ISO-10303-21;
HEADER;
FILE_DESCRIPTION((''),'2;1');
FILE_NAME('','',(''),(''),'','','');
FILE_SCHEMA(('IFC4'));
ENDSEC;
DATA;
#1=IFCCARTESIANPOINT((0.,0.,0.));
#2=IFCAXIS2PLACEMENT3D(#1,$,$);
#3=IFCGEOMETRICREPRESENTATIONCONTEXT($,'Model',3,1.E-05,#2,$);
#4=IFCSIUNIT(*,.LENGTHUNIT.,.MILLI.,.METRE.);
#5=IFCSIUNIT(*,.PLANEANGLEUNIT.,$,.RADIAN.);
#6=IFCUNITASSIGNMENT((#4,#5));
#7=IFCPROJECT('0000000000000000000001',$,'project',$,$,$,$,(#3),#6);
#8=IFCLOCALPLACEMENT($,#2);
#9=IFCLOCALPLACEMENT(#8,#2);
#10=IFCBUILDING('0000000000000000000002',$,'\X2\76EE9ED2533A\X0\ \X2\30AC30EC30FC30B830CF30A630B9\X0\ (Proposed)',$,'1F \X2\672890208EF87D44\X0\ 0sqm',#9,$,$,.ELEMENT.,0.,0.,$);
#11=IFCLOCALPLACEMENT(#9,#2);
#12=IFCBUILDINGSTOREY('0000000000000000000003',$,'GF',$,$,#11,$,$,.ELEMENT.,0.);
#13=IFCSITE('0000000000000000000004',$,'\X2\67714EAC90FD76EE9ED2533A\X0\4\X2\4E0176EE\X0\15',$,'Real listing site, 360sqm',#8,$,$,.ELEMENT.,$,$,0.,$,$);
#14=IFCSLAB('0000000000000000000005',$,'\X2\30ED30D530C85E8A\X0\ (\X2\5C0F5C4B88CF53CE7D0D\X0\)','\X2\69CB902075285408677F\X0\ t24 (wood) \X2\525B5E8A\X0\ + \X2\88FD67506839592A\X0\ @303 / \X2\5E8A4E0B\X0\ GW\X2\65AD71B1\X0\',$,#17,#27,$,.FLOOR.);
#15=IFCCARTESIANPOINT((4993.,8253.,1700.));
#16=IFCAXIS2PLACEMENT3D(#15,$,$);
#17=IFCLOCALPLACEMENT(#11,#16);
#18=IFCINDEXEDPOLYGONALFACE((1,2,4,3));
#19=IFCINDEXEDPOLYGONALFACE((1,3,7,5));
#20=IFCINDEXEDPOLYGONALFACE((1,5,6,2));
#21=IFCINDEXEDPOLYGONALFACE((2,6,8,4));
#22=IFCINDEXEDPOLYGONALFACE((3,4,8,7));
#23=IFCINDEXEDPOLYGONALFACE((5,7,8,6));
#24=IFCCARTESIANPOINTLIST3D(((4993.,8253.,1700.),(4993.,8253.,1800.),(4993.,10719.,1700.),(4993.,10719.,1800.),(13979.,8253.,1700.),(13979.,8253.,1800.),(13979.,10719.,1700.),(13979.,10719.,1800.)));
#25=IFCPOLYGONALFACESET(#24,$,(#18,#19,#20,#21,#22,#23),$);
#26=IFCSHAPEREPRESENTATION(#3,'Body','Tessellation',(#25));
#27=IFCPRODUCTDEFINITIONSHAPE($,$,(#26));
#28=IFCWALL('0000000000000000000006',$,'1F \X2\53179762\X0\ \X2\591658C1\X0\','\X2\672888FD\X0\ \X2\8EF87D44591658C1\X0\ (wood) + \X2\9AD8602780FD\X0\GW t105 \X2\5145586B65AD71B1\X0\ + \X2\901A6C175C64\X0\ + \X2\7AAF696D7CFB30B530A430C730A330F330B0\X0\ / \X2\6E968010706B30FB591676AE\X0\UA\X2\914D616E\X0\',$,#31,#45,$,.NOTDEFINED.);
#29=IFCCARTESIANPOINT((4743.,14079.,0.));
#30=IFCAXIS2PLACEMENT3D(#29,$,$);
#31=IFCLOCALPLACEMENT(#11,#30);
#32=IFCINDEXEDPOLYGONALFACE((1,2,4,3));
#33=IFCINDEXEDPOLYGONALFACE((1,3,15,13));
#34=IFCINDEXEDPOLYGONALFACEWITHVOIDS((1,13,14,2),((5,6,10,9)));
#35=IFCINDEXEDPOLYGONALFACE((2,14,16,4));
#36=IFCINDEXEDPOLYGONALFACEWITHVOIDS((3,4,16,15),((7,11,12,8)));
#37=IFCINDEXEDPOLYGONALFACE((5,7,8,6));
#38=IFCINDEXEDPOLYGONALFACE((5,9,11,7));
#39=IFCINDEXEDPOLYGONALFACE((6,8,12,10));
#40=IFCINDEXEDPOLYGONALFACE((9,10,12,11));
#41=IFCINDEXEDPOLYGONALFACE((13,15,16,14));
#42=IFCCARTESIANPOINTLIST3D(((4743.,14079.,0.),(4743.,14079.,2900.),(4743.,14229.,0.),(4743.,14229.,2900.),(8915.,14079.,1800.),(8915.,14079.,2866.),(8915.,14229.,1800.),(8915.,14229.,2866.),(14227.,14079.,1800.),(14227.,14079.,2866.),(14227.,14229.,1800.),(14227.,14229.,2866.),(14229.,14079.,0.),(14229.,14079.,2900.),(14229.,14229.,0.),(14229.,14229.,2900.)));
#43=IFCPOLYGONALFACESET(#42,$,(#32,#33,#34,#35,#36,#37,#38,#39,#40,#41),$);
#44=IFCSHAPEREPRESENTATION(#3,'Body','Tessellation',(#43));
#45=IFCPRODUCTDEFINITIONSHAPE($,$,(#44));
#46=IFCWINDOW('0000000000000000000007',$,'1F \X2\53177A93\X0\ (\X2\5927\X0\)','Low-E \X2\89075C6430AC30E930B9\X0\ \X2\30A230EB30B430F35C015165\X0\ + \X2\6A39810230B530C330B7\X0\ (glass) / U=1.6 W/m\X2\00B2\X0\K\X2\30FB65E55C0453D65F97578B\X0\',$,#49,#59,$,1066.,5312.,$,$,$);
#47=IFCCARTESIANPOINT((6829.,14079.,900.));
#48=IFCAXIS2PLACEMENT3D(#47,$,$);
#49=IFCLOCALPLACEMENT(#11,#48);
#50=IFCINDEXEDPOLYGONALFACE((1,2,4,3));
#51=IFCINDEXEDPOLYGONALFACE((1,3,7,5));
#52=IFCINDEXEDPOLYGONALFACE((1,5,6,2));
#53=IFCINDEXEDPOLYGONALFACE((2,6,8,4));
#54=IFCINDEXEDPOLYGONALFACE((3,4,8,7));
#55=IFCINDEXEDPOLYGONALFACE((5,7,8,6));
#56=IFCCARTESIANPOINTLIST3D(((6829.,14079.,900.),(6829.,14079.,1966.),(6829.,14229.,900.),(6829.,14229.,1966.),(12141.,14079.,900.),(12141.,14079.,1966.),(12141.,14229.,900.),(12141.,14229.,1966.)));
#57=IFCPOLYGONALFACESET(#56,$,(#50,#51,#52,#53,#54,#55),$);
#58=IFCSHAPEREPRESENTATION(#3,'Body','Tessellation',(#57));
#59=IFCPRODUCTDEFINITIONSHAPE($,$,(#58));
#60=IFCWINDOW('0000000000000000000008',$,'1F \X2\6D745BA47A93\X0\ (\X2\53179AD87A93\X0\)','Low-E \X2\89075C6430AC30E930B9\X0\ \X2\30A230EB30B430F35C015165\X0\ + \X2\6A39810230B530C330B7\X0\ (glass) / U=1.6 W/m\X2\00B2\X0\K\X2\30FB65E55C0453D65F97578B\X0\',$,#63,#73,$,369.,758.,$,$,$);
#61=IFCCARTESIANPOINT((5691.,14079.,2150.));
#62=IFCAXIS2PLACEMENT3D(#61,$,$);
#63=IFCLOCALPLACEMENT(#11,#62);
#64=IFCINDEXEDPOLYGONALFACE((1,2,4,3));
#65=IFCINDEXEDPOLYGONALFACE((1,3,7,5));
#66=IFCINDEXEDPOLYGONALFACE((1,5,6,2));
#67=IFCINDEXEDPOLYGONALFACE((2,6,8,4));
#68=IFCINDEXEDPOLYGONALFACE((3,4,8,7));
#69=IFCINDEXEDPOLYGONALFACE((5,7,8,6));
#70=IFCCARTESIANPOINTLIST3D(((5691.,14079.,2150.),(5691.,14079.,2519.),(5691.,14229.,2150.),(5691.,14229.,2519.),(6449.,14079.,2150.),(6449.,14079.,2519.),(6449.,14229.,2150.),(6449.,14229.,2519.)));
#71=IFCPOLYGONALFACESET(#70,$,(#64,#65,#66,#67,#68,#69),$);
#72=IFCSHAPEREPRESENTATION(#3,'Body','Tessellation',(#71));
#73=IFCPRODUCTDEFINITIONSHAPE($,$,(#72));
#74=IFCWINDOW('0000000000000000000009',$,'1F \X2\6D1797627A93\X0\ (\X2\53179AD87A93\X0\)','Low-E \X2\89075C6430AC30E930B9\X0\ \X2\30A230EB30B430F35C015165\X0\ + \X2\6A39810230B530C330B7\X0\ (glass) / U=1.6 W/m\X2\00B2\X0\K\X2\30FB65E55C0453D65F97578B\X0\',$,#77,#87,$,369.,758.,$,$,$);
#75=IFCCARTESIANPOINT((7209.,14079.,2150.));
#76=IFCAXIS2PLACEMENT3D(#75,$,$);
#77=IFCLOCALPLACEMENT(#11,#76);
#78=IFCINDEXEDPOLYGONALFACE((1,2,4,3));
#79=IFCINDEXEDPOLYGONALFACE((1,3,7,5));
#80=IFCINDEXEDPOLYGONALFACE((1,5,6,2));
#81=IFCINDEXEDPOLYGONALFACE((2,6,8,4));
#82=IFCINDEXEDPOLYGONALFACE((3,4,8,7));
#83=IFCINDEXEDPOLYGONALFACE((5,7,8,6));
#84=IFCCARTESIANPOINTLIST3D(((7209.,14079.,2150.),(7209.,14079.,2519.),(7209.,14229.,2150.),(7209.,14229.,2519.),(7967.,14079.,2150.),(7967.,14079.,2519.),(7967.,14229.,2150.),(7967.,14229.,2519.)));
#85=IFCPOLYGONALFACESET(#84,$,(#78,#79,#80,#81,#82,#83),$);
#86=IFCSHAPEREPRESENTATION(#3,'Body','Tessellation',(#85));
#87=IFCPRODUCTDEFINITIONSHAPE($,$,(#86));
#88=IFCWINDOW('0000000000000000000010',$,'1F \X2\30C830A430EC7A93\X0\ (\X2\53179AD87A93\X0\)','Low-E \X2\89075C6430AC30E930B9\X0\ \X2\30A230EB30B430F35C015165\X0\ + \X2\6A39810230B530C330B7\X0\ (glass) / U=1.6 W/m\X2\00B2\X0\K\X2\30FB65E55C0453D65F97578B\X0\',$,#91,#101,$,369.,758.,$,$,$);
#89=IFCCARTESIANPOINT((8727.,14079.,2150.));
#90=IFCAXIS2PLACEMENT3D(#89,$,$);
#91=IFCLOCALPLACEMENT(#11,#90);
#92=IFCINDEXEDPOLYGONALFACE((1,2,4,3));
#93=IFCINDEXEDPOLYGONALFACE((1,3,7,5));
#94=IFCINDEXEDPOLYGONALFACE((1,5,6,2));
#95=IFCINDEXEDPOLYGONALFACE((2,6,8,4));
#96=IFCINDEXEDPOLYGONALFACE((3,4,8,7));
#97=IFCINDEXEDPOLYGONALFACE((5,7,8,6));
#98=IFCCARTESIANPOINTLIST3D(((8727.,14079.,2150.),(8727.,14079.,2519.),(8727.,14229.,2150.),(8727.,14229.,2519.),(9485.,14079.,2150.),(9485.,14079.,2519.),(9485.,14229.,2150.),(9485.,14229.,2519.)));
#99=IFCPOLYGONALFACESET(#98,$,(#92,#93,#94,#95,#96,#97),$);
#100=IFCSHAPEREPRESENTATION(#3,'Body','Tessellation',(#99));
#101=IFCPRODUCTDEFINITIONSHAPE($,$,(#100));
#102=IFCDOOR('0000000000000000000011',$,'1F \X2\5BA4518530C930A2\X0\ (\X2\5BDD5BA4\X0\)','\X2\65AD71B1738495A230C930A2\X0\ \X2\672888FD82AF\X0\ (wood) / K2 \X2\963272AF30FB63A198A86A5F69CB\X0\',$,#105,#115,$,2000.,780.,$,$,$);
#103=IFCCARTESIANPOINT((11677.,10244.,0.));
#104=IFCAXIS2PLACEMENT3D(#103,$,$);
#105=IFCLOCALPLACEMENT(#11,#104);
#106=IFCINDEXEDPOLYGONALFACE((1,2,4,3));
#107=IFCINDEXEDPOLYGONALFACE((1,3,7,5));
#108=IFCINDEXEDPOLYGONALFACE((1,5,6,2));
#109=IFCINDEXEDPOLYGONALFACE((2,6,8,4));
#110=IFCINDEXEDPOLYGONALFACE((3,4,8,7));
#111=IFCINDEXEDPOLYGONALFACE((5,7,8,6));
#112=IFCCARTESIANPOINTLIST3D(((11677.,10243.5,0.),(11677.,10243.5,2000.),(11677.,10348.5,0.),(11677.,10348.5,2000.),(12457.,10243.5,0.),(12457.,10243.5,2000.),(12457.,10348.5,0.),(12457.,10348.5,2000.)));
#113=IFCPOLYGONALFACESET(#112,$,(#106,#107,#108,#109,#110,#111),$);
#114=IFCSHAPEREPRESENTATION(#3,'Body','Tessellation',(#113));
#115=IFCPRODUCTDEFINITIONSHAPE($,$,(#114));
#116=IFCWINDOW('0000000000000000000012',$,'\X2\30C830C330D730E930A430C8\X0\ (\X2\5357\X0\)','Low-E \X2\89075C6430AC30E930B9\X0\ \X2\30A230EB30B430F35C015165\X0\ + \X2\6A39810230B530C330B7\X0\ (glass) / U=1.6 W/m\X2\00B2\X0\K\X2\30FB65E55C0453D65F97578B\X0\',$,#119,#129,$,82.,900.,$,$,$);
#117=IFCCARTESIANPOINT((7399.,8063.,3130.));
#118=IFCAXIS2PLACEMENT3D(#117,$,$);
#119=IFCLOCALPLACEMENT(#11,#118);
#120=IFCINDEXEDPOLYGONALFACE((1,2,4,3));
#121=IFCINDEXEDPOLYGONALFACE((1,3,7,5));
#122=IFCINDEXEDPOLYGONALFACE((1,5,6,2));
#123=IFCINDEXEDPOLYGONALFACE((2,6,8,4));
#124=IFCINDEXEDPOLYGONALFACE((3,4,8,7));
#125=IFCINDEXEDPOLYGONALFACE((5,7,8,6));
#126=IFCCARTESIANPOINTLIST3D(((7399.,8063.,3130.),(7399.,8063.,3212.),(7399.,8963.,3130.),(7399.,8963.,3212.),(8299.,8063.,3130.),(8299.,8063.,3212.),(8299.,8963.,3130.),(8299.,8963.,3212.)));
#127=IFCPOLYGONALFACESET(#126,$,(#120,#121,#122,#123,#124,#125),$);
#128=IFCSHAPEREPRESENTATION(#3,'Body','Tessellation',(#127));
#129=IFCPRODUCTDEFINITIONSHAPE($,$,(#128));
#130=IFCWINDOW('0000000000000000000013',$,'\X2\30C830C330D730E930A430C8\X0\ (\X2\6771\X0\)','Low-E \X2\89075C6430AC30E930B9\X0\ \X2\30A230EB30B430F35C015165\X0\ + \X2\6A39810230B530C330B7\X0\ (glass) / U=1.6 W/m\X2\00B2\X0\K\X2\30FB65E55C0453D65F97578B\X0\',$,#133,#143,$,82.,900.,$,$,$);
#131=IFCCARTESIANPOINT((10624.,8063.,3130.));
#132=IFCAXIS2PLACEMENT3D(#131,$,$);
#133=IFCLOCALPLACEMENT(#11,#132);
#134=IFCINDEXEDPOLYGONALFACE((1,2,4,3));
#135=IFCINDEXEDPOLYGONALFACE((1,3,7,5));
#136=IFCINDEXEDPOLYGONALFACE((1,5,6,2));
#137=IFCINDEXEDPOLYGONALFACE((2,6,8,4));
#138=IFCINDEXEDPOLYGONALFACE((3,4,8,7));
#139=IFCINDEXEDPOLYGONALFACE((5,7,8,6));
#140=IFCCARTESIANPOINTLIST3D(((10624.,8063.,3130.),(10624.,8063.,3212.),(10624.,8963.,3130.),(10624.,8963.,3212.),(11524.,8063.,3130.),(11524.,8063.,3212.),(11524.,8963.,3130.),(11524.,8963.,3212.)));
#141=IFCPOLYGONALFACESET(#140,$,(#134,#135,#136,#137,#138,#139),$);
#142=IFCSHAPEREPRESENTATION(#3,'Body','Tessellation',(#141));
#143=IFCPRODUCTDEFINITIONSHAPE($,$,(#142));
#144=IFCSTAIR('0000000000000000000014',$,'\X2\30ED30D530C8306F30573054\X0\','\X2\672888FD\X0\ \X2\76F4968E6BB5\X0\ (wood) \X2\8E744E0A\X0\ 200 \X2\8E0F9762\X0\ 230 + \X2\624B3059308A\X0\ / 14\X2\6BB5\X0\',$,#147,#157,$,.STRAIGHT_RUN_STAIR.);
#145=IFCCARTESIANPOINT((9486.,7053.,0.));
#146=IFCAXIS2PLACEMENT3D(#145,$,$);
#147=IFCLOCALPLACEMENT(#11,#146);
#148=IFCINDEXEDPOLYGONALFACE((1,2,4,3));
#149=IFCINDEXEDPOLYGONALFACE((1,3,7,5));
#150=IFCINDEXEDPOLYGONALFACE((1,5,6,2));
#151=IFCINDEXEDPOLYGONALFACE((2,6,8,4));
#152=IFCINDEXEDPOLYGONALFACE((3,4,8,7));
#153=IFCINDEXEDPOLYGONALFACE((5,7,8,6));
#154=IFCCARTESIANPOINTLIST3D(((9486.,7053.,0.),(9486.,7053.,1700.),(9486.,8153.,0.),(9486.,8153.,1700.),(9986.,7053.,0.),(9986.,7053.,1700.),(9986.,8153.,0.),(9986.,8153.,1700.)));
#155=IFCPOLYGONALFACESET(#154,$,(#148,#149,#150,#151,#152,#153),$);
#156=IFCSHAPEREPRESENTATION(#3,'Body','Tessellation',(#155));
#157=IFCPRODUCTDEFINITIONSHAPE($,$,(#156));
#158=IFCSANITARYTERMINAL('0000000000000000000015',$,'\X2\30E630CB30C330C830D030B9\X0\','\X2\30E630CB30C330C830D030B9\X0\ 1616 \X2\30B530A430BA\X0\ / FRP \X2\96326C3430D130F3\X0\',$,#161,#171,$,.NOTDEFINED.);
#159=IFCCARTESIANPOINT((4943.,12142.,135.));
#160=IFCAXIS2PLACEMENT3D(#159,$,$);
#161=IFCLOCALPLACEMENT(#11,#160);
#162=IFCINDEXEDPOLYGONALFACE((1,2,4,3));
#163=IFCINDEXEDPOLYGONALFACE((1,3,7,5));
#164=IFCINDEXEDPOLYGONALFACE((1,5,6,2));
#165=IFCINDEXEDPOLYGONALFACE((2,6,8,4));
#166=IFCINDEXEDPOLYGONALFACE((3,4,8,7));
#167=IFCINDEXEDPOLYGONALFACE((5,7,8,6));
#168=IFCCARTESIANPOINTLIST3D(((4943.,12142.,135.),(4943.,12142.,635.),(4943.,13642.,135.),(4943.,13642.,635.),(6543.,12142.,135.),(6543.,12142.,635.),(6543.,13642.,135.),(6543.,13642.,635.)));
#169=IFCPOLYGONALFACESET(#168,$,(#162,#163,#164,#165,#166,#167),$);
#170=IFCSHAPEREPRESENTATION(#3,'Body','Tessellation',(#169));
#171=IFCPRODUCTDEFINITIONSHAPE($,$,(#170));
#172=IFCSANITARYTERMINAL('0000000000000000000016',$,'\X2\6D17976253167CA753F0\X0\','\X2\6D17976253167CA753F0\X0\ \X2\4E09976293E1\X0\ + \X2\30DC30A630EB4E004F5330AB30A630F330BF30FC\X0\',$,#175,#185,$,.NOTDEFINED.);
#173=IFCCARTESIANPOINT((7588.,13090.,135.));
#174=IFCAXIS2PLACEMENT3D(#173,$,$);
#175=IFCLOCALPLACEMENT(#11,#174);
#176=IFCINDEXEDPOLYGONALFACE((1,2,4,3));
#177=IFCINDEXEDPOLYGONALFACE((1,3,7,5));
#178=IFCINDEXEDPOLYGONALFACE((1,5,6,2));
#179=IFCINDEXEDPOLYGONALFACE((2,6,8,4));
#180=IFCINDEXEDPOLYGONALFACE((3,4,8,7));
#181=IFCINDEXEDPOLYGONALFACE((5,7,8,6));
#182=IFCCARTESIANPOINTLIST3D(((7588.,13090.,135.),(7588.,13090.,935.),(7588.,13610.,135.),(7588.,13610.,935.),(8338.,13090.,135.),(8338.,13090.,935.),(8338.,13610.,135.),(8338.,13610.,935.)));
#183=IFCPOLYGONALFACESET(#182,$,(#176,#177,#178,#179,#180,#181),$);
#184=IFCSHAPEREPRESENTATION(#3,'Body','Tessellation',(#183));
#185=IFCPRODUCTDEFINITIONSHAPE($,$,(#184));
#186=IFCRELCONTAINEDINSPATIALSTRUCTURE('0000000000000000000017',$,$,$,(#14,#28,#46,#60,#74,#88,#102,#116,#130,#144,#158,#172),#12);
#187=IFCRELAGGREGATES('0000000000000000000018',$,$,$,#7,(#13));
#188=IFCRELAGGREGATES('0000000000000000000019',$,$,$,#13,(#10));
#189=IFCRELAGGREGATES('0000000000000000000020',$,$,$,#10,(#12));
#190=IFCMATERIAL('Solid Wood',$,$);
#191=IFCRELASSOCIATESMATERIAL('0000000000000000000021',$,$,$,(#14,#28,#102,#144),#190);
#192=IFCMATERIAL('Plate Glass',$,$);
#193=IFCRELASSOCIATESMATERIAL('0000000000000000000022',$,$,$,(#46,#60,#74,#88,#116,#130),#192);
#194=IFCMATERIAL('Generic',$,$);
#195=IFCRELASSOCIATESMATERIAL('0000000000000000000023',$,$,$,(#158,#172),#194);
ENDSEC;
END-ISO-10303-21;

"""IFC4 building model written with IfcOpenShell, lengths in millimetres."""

from ifc_helpers import new_model, si_unit, frame, frame_2d, origin, place, context, project, spatial, rectangle, extrude, material, element, fill, save


model = new_model("IFC4")

# Units and contexts
model_context = context("Model", 3, precision=1e-05, world=origin())
ifc_project = project(units=[si_unit("LENGTHUNIT", "METRE", prefix="MILLI"), si_unit("PLANEANGLEUNIT", "RADIAN")], contexts=[model_context])

# Site, building, storey
site_placement = place(None, origin())
site = spatial("IfcSite", under=ifc_project, at=site_placement, Name="東京都目黒区4丁目15", ObjectType="Real listing site, 360sqm", CompositionType="ELEMENT", RefElevation=0.0)
building_placement = place(site_placement, origin())
building = spatial("IfcBuilding", under=site, at=building_placement, Name="目黒区 ガレージハウス (Proposed)", ObjectType="1F 木造軸組 0sqm", CompositionType="ELEMENT", ElevationOfRefHeight=0.0, ElevationOfTerrain=0.0)
storey_placement = place(building_placement, origin())
storey = spatial("IfcBuildingStorey", under=building, at=storey_placement, Name="GF", CompositionType="ELEMENT", Elevation=0.0)

# Slab
ifc_material_1 = material(Name="Solid Wood")
slab_placement = place(storey_placement, frame((4993.0, 8253.0, 1700.0)))
element("IfcSlab", 1, at=slab_placement, inside=storey, material=ifc_material_1, Name="ロフト床 (小屋裏収納)", Description="構造用合板 t24 (wood) 剛床 + 製材根太 @303 / 床下 GW断熱", PredefinedType="FLOOR", context=model_context, shape_type="SweptSolid", body=[
    extrude(rectangle(XDim=8986.0, YDim=2466.0, at=frame_2d((4493.0, 1233.0))), frame((4993.0, 8253.0, 1700.0)), (0.0, 0.0, 1.0), 100.0),
])

# Wall, openings, windows
wall_1_placement = place(storey_placement, frame((4743.0, 14079.0, 0.0)))
wall_1 = element("IfcWall", 2, at=wall_1_placement, inside=storey, material=ifc_material_1, Name="1F 北面 外壁", Description="木製 軸組外壁 (wood) + 高性能GW t105 充填断熱 + 通気層 + 窯業系サイディング / 準耐火・外皮UA配慮", PredefinedType="NOTDEFINED", context=model_context, shape_type="SweptSolid", body=[
    extrude(rectangle(XDim=9486.0, YDim=150.0, at=frame_2d((4743.0, 75.0))), frame((4743.0, 14079.0, 0.0)), (0.0, 0.0, 1.0), 2900.0),
])
opening_1_placement = place(storey_placement, frame((6829.0, 14079.0, 900.0)))
opening_1 = element("IfcOpeningElement", 3, at=opening_1_placement, cuts=wall_1, PredefinedType="NOTDEFINED", context=model_context, shape_type="SweptSolid", body=[
    extrude(rectangle(XDim=5312.0, YDim=150.0, at=frame_2d((2656.0, 75.0))), frame((6829.0, 14079.0, 900.0)), (0.0, 0.0, 1.0), 1066.0),
])
opening_2_placement = place(storey_placement, frame((5691.0, 14079.0, 2150.0)))
opening_2 = element("IfcOpeningElement", 4, at=opening_2_placement, cuts=wall_1, PredefinedType="NOTDEFINED", context=model_context, shape_type="SweptSolid", body=[
    extrude(rectangle(XDim=758.0, YDim=150.0, at=frame_2d((379.0, 75.0))), frame((5691.0, 14079.0, 2150.0)), (0.0, 0.0, 1.0), 369.0),
])
opening_3_placement = place(storey_placement, frame((7209.0, 14079.0, 2150.0)))
opening_3 = element("IfcOpeningElement", 5, at=opening_3_placement, cuts=wall_1, PredefinedType="NOTDEFINED", context=model_context, shape_type="SweptSolid", body=[
    extrude(rectangle(XDim=758.0, YDim=150.0, at=frame_2d((379.0, 75.0))), frame((7209.0, 14079.0, 2150.0)), (0.0, 0.0, 1.0), 369.0),
])
opening_4_placement = place(storey_placement, frame((8727.0, 14079.0, 2150.0)))
opening_4 = element("IfcOpeningElement", 6, at=opening_4_placement, cuts=wall_1, PredefinedType="NOTDEFINED", context=model_context, shape_type="SweptSolid", body=[
    extrude(rectangle(XDim=758.0, YDim=150.0, at=frame_2d((379.0, 75.0))), frame((8727.0, 14079.0, 2150.0)), (0.0, 0.0, 1.0), 369.0),
])
ifc_material_2 = material(Name="Plate Glass")
window_1_placement = place(storey_placement, frame((6829.0, 14079.0, 900.0)))
window_1 = element("IfcWindow", 7, at=window_1_placement, inside=storey, material=ifc_material_2, Name="1F 北窓 (大)", Description="Low-E 複層ガラス アルゴン封入 + 樹脂サッシ (glass) / U=1.6 W/m²K・日射取得型", OverallHeight=1066.0, OverallWidth=5312.0, context=model_context, shape_type="SweptSolid", body=[
    extrude(rectangle(XDim=5312.0, YDim=150.0, at=frame_2d((2656.0, 75.0))), frame((6829.0, 14079.0, 900.0)), (0.0, 0.0, 1.0), 1066.0),
])
fill(opening_1, window_1)
window_2_placement = place(storey_placement, frame((5691.0, 14079.0, 2150.0)))
window_2 = element("IfcWindow", 8, at=window_2_placement, inside=storey, material=ifc_material_2, Name="1F 浴室窓 (北高窓)", Description="Low-E 複層ガラス アルゴン封入 + 樹脂サッシ (glass) / U=1.6 W/m²K・日射取得型", OverallHeight=369.0, OverallWidth=758.0, context=model_context, shape_type="SweptSolid", body=[
    extrude(rectangle(XDim=758.0, YDim=150.0, at=frame_2d((379.0, 75.0))), frame((5691.0, 14079.0, 2150.0)), (0.0, 0.0, 1.0), 369.0),
])
fill(opening_2, window_2)
window_3_placement = place(storey_placement, frame((7209.0, 14079.0, 2150.0)))
window_3 = element("IfcWindow", 9, at=window_3_placement, inside=storey, material=ifc_material_2, Name="1F 洗面窓 (北高窓)", Description="Low-E 複層ガラス アルゴン封入 + 樹脂サッシ (glass) / U=1.6 W/m²K・日射取得型", OverallHeight=369.0, OverallWidth=758.0, context=model_context, shape_type="SweptSolid", body=[
    extrude(rectangle(XDim=758.0, YDim=150.0, at=frame_2d((379.0, 75.0))), frame((7209.0, 14079.0, 2150.0)), (0.0, 0.0, 1.0), 369.0),
])
fill(opening_3, window_3)
window_4_placement = place(storey_placement, frame((8727.0, 14079.0, 2150.0)))
window_4 = element("IfcWindow", 10, at=window_4_placement, inside=storey, material=ifc_material_2, Name="1F トイレ窓 (北高窓)", Description="Low-E 複層ガラス アルゴン封入 + 樹脂サッシ (glass) / U=1.6 W/m²K・日射取得型", OverallHeight=369.0, OverallWidth=758.0, context=model_context, shape_type="SweptSolid", body=[
    extrude(rectangle(XDim=758.0, YDim=150.0, at=frame_2d((379.0, 75.0))), frame((8727.0, 14079.0, 2150.0)), (0.0, 0.0, 1.0), 369.0),
])
fill(opening_4, window_4)

# Door
door_1_placement = place(storey_placement, frame((11677.0, 10244.0, 0.0)))
element("IfcDoor", 11, at=door_1_placement, inside=storey, material=ifc_material_1, Name="1F 室内ドア (寝室)", Description="断熱玄関ドア 木製芯 (wood) / K2 防犯・採風機構", OverallHeight=2000.0, OverallWidth=780.0, context=model_context, shape_type="SweptSolid", body=[
    extrude(rectangle(XDim=780.0, YDim=105.0, at=frame_2d((390.0, 52.0))), frame((11677.0, 10244.0, 0.0)), (0.0, 0.0, 1.0), 2000.0),
])

# Windows
window_5_placement = place(storey_placement, frame((7399.0, 8063.0, 3130.0)))
element("IfcWindow", 12, at=window_5_placement, inside=storey, material=ifc_material_2, Name="トップライト (南)", Description="Low-E 複層ガラス アルゴン封入 + 樹脂サッシ (glass) / U=1.6 W/m²K・日射取得型", OverallHeight=82.0, OverallWidth=900.0, context=model_context, shape_type="SweptSolid", body=[
    extrude(rectangle(XDim=900.0, YDim=900.0, at=frame_2d((450.0, 450.0))), frame((7399.0, 8063.0, 3130.0)), (0.0, 0.0, 1.0), 82.0),
])
window_6_placement = place(storey_placement, frame((10624.0, 8063.0, 3130.0)))
element("IfcWindow", 13, at=window_6_placement, inside=storey, material=ifc_material_2, Name="トップライト (東)", Description="Low-E 複層ガラス アルゴン封入 + 樹脂サッシ (glass) / U=1.6 W/m²K・日射取得型", OverallHeight=82.0, OverallWidth=900.0, context=model_context, shape_type="SweptSolid", body=[
    extrude(rectangle(XDim=900.0, YDim=900.0, at=frame_2d((450.0, 450.0))), frame((10624.0, 8063.0, 3130.0)), (0.0, 0.0, 1.0), 82.0),
])

# Stair
stair_placement = place(storey_placement, frame((9486.0, 7053.0, 0.0)))
element("IfcStair", 14, at=stair_placement, inside=storey, material=ifc_material_1, Name="ロフトはしご", Description="木製 直階段 (wood) 蹴上 200 踏面 230 + 手すり / 14段", PredefinedType="STRAIGHT_RUN_STAIR", context=model_context, shape_type="SweptSolid", body=[
    extrude(rectangle(XDim=500.0, YDim=1100.0, at=frame_2d((250.0, 550.0))), frame((9486.0, 7053.0, 0.0)), (0.0, 0.0, 1.0), 1700.0),
])

# Sanitary terminals
ifc_material_3 = material(Name="Generic")
sanitary_terminal_1_placement = place(storey_placement, frame((4943.0, 12142.0, 135.0)))
element("IfcSanitaryTerminal", 15, at=sanitary_terminal_1_placement, inside=storey, material=ifc_material_3, Name="ユニットバス", Description="ユニットバス 1616 サイズ / FRP 防水パン", PredefinedType="NOTDEFINED", context=model_context, shape_type="SweptSolid", body=[
    extrude(rectangle(XDim=1600.0, YDim=1500.0, at=frame_2d((800.0, 750.0))), frame((4943.0, 12142.0, 135.0)), (0.0, 0.0, 1.0), 500.0),
])
sanitary_terminal_2_placement = place(storey_placement, frame((7588.0, 13090.0, 135.0)))
element("IfcSanitaryTerminal", 16, at=sanitary_terminal_2_placement, inside=storey, material=ifc_material_3, Name="洗面化粧台", Description="洗面化粧台 三面鏡 + ボウル一体カウンター", PredefinedType="NOTDEFINED", context=model_context, shape_type="SweptSolid", body=[
    extrude(rectangle(XDim=750.0, YDim=520.0, at=frame_2d((375.0, 260.0))), frame((7588.0, 13090.0, 135.0)), (0.0, 0.0, 1.0), 800.0),
])

save(model, "model.ifc")
